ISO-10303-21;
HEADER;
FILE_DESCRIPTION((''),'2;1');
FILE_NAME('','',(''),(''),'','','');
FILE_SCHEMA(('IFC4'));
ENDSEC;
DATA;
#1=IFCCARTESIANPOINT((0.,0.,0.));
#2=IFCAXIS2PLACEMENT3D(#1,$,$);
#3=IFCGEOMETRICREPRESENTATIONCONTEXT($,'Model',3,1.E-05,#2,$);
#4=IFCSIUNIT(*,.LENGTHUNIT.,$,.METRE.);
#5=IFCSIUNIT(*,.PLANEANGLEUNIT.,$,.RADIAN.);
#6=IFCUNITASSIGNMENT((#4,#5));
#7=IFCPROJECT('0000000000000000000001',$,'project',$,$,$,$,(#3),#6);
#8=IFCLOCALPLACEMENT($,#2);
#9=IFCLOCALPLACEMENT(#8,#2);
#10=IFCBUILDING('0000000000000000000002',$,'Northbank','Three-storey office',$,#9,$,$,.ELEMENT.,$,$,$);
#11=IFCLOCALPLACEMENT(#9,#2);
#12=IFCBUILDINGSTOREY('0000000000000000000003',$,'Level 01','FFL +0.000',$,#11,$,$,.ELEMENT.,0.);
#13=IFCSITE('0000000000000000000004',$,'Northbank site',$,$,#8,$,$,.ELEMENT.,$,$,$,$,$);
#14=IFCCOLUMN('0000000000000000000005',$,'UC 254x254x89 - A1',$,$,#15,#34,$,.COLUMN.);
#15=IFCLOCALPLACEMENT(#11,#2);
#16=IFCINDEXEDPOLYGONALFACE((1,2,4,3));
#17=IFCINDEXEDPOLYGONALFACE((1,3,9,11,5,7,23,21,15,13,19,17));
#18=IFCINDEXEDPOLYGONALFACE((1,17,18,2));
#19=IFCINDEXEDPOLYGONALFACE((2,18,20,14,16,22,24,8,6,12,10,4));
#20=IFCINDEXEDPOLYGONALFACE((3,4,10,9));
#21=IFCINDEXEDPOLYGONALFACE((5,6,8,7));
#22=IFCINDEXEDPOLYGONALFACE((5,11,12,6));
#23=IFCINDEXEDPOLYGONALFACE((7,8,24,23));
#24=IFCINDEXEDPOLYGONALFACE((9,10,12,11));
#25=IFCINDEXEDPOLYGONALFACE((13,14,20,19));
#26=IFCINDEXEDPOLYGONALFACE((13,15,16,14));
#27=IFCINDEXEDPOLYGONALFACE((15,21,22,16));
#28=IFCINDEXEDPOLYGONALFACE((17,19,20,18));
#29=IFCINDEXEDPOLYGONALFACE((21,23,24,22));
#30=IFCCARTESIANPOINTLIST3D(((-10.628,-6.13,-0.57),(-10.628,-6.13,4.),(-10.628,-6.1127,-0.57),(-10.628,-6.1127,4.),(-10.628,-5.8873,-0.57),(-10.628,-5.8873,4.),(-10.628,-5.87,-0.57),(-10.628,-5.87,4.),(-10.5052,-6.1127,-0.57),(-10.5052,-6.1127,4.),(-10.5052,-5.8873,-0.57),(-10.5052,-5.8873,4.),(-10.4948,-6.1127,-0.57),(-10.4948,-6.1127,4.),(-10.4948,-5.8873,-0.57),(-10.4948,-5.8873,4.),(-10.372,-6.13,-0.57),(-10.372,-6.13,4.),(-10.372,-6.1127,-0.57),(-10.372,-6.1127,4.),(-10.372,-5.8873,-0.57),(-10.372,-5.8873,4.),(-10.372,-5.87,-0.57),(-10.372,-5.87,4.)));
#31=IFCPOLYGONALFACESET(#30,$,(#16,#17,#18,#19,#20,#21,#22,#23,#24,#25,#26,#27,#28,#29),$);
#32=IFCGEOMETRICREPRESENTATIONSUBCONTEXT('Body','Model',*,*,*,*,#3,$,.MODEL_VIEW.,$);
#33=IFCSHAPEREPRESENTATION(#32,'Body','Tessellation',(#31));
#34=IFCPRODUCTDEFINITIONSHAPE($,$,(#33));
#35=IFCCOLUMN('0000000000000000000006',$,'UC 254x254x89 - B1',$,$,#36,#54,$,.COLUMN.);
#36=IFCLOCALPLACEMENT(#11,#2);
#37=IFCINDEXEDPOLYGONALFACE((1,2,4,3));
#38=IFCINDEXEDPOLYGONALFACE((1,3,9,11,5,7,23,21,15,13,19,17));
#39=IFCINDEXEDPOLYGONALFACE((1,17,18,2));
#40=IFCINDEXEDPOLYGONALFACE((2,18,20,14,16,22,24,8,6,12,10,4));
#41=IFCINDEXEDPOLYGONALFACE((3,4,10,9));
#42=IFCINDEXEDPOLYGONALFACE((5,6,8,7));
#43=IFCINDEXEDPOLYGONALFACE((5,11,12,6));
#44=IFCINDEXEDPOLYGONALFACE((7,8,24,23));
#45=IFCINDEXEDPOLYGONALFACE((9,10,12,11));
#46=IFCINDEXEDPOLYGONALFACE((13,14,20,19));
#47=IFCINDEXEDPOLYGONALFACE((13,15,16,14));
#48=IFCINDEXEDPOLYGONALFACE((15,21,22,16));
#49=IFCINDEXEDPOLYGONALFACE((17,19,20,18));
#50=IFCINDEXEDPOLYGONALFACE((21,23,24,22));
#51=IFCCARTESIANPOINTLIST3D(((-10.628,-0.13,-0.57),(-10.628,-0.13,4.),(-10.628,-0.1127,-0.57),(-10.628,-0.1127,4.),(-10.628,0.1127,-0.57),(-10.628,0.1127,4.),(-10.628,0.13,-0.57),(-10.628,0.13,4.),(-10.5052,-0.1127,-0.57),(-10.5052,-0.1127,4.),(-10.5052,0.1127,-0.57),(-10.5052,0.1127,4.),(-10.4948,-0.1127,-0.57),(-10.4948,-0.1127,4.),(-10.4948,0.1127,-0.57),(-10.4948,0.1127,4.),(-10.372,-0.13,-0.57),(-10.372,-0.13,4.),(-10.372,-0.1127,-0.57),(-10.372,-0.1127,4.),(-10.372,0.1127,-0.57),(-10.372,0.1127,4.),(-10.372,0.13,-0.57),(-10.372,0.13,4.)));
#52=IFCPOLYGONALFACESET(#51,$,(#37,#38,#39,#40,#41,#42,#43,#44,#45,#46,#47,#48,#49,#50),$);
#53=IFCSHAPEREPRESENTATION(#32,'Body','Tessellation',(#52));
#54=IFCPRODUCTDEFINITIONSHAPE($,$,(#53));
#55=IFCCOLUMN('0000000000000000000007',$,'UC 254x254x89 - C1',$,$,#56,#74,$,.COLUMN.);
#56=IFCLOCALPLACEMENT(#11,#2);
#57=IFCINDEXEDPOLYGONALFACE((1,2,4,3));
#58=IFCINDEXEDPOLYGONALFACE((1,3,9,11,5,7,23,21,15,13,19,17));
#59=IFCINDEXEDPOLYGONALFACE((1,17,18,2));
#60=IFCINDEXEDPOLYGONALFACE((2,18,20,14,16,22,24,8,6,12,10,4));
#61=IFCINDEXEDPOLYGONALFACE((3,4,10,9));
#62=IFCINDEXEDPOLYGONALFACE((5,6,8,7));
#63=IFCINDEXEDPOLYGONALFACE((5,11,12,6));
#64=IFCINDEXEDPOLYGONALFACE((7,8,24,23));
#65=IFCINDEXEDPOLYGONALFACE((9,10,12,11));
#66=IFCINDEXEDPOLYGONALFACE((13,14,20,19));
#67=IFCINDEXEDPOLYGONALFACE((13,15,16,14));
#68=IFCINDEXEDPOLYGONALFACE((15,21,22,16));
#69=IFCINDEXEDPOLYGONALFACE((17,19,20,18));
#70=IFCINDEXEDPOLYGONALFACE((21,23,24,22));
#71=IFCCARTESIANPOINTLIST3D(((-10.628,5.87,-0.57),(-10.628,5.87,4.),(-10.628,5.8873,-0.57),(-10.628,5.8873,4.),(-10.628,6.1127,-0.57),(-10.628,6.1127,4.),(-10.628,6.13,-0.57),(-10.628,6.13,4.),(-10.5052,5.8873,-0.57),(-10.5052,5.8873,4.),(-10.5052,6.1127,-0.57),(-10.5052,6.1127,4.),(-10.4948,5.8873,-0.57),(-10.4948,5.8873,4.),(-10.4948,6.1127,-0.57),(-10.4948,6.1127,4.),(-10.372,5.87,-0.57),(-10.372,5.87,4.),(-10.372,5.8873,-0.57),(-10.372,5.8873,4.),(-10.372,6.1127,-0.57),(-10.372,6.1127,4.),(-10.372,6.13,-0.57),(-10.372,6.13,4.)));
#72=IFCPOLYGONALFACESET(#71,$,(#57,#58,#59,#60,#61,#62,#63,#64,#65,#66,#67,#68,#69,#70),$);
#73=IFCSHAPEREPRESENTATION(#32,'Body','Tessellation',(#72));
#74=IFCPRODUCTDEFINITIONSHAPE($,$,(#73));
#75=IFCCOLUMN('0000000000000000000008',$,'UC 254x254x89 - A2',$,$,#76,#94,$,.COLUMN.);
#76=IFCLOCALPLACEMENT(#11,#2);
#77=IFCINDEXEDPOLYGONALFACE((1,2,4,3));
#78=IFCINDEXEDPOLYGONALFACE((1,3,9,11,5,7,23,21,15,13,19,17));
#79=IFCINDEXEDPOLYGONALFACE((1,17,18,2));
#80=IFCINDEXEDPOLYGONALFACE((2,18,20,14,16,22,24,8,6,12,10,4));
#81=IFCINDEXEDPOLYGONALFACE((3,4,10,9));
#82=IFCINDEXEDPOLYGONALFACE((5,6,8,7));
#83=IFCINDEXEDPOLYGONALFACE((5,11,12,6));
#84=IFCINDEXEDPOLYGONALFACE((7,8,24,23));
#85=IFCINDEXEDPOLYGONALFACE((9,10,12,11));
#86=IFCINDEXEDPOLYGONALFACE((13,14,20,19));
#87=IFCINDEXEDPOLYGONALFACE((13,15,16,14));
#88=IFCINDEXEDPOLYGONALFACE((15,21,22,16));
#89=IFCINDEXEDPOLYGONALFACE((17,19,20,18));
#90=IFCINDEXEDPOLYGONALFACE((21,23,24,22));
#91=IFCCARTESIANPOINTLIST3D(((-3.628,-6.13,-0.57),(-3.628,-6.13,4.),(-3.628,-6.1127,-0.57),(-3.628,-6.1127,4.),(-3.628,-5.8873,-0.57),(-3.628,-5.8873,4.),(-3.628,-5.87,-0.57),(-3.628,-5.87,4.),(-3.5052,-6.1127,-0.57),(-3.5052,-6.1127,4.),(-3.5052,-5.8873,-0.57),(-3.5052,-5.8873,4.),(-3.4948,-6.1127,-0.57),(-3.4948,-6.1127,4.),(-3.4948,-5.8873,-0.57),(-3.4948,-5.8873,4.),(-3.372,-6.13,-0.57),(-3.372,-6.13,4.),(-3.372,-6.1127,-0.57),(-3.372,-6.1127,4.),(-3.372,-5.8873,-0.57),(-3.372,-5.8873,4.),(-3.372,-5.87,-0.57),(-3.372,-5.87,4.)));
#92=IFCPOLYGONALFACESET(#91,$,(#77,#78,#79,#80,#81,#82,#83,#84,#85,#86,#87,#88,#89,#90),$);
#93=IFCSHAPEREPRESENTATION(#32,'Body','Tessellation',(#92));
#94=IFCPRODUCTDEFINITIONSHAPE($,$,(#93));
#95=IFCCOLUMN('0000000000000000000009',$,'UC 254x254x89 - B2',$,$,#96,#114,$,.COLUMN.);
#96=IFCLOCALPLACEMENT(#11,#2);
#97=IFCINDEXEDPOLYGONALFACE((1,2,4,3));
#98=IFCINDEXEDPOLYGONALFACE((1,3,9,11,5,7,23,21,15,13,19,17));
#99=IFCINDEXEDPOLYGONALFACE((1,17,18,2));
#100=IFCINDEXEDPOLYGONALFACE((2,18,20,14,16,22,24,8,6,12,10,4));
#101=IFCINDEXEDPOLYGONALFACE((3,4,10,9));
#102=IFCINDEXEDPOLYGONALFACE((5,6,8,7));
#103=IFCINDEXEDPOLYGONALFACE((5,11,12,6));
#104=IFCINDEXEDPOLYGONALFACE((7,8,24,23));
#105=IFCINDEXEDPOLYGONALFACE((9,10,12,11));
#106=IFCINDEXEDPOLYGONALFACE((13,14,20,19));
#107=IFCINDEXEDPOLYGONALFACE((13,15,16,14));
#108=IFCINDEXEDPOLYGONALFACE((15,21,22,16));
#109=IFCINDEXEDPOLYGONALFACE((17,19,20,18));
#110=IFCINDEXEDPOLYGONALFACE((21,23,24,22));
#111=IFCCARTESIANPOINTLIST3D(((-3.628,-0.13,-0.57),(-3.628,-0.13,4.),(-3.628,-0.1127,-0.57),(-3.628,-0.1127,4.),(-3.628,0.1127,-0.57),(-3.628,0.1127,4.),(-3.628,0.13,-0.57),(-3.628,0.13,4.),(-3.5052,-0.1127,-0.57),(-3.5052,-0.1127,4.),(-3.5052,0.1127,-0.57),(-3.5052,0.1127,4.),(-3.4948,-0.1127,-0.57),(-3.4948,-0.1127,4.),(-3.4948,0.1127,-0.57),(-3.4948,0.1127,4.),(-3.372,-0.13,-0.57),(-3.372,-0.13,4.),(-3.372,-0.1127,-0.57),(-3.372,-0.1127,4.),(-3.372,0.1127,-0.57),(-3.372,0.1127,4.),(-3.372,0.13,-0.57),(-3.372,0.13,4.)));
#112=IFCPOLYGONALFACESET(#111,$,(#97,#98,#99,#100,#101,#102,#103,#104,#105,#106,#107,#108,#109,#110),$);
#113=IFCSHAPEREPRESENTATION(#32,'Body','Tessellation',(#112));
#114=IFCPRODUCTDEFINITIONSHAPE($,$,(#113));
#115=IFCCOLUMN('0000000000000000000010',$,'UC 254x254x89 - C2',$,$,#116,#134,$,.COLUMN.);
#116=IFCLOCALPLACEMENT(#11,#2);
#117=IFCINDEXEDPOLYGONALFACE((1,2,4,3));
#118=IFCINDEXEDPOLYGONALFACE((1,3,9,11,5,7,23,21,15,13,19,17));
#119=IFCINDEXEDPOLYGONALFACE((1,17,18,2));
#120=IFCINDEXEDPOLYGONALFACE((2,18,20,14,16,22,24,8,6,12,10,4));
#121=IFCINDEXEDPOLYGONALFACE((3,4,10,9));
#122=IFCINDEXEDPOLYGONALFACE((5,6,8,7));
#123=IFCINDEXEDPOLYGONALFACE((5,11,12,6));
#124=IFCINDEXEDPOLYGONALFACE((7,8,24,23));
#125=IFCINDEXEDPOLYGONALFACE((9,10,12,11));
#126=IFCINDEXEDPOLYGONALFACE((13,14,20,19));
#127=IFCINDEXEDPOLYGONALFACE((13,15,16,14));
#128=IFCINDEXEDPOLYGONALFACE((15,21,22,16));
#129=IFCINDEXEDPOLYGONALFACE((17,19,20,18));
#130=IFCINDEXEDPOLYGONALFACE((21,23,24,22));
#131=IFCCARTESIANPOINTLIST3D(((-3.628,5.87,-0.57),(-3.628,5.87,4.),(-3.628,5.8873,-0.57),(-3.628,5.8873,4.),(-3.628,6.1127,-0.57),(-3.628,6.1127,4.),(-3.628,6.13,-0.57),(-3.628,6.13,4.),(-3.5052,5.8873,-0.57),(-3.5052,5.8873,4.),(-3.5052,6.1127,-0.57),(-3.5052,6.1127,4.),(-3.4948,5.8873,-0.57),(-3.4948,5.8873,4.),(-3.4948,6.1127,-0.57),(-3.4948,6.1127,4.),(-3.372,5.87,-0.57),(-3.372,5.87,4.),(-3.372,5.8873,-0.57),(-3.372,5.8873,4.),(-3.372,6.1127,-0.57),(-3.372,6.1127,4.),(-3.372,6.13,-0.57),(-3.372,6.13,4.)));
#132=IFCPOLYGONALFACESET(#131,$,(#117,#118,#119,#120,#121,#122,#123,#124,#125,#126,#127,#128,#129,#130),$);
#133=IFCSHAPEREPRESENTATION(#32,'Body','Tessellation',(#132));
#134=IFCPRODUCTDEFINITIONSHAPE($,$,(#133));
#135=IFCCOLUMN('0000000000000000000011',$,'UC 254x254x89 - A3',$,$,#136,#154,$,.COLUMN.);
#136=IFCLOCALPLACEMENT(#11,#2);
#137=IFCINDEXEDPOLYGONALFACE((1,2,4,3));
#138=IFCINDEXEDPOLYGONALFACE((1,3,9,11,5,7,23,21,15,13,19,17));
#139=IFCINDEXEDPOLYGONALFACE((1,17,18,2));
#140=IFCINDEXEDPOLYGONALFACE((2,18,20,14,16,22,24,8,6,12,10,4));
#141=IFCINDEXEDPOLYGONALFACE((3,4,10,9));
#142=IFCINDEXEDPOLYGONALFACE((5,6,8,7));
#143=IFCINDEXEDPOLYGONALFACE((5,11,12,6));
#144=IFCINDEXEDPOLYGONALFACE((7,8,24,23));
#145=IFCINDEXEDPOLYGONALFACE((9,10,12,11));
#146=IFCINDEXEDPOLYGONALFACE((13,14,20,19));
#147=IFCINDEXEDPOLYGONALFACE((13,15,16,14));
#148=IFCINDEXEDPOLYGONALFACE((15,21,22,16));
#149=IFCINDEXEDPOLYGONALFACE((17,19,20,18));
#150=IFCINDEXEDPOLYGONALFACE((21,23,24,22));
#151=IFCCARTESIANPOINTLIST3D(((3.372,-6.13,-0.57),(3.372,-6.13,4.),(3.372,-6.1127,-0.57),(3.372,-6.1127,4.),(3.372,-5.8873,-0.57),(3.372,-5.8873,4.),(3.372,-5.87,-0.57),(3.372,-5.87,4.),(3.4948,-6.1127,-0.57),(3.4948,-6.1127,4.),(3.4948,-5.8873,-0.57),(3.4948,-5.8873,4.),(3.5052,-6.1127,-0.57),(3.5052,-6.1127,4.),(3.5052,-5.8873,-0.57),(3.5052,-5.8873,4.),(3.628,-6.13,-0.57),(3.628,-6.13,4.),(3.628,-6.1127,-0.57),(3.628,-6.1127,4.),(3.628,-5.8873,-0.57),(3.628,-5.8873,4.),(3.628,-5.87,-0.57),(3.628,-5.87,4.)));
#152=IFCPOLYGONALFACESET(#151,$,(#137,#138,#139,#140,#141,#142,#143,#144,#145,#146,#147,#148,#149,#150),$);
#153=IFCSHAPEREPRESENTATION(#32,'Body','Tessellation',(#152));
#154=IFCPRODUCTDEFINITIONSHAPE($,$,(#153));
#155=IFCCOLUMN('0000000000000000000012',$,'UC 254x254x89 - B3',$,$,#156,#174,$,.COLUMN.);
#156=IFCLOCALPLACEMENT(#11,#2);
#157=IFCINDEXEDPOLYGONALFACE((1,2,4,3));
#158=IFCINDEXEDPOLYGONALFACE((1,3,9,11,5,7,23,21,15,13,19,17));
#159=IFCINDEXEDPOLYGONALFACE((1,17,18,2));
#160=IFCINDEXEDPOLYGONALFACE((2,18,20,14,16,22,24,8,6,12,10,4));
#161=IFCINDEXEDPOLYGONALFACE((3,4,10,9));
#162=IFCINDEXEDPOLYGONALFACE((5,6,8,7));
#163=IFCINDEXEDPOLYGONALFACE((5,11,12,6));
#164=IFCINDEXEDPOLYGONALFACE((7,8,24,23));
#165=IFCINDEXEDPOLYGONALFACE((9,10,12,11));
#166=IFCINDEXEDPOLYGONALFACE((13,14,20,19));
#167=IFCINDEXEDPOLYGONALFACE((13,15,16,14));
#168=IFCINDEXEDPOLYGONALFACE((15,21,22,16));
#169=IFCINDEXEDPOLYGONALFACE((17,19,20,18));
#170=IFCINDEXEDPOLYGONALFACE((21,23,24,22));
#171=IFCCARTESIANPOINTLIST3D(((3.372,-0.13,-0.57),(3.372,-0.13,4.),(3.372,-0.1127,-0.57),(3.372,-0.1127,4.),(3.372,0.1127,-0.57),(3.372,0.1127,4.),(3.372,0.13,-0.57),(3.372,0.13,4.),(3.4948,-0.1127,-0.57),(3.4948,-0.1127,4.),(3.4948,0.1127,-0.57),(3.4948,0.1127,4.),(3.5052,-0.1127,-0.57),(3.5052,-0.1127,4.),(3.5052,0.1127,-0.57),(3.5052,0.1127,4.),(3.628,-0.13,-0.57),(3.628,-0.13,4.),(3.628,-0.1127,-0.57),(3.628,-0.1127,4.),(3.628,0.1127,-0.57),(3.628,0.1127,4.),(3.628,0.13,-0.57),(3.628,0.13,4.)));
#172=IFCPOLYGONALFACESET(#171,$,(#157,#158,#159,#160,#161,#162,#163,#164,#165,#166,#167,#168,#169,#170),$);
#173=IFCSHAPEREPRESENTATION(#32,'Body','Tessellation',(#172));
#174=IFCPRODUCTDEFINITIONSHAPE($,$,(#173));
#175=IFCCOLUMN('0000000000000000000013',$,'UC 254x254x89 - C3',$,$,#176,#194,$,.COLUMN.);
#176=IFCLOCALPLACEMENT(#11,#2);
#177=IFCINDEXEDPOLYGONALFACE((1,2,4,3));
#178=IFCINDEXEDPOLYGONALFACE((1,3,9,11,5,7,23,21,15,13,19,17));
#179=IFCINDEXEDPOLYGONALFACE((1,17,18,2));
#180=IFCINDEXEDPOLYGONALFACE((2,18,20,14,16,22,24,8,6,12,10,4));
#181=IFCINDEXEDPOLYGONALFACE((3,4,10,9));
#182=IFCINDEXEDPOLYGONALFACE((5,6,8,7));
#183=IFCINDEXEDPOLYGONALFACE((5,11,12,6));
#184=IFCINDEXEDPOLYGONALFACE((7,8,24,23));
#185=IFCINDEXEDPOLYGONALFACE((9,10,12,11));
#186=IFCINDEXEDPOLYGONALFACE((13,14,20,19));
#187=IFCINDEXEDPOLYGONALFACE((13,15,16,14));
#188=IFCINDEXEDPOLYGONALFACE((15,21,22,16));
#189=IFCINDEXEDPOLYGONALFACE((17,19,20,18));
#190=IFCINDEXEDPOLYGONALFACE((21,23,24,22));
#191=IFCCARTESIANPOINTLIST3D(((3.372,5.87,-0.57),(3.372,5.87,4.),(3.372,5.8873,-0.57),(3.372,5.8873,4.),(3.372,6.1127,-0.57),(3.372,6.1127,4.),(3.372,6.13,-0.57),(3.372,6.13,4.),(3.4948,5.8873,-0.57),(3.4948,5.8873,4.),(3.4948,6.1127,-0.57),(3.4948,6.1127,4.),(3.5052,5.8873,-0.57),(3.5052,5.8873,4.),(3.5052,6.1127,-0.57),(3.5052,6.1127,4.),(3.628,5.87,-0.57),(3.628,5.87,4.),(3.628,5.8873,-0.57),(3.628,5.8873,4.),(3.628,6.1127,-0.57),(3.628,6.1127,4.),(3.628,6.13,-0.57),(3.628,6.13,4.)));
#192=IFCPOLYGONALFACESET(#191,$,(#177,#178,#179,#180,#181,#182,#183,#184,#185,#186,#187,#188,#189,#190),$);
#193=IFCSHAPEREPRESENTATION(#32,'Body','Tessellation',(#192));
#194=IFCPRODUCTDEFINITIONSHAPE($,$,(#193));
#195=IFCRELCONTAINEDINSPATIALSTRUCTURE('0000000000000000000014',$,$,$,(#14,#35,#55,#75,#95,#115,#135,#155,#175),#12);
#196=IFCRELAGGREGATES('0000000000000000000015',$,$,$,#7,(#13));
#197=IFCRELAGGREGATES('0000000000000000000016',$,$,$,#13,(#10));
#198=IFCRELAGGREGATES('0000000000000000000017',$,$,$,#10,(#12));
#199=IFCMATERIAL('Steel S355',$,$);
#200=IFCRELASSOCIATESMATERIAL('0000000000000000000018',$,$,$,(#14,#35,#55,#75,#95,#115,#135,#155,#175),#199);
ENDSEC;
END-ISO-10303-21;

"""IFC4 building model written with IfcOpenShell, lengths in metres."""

from ifc_helpers import new_model, si_unit, frame, origin, place, context, subcontext, project, spatial, i_section, extrude, material, element, save


model = new_model("IFC4")

# Units and contexts
model_context = context("Model", 3, precision=1e-05, world=origin())
body_context = subcontext(model_context, "Body", "Model", "MODEL_VIEW")
ifc_project = project(units=[si_unit("LENGTHUNIT", "METRE"), si_unit("PLANEANGLEUNIT", "RADIAN")], contexts=[model_context])

# Site, building, storey
site_placement = place(None, origin())
site = spatial("IfcSite", under=ifc_project, at=site_placement, Name="Northbank site", CompositionType="ELEMENT")
building_placement = place(site_placement, origin())
building = spatial("IfcBuilding", under=site, at=building_placement, Name="Northbank", Description="Three-storey office", CompositionType="ELEMENT")
storey_placement = place(building_placement, origin())
storey = spatial("IfcBuildingStorey", under=building, at=storey_placement, Name="Level 01", Description="FFL +0.000", CompositionType="ELEMENT", Elevation=0.0)

# Columns
ifc_material_1 = material(Name="Steel S355")
column_1_placement = place(storey_placement, origin())
element("IfcColumn", 1, at=column_1_placement, inside=storey, material=ifc_material_1, Name="UC 254x254x89 - A1", PredefinedType="COLUMN", context=body_context, shape_type="SweptSolid", body=[
    extrude(i_section(OverallWidth=0.256, OverallDepth=0.26, WebThickness=0.0103, FlangeThickness=0.0173), frame((-10.5, -6.0, -0.57), z_axis=(0.0, 0.0, 1.0), x_axis=(1.0, 0.0, 0.0)), (0.0, 0.0, 1.0), 4.57),
])
column_2_placement = place(storey_placement, origin())
element("IfcColumn", 2, at=column_2_placement, inside=storey, material=ifc_material_1, Name="UC 254x254x89 - B1", PredefinedType="COLUMN", context=body_context, shape_type="SweptSolid", body=[
    extrude(i_section(OverallWidth=0.256, OverallDepth=0.26, WebThickness=0.0103, FlangeThickness=0.0173), frame((-10.5, 0.0, -0.57), z_axis=(0.0, 0.0, 1.0), x_axis=(1.0, 0.0, 0.0)), (0.0, 0.0, 1.0), 4.57),
])
column_3_placement = place(storey_placement, origin())
element("IfcColumn", 3, at=column_3_placement, inside=storey, material=ifc_material_1, Name="UC 254x254x89 - C1", PredefinedType="COLUMN", context=body_context, shape_type="SweptSolid", body=[
    extrude(i_section(OverallWidth=0.256, OverallDepth=0.26, WebThickness=0.0103, FlangeThickness=0.0173), frame((-10.5, 6.0, -0.57), z_axis=(0.0, 0.0, 1.0), x_axis=(1.0, 0.0, 0.0)), (0.0, 0.0, 1.0), 4.57),
])
column_4_placement = place(storey_placement, origin())
element("IfcColumn", 4, at=column_4_placement, inside=storey, material=ifc_material_1, Name="UC 254x254x89 - A2", PredefinedType="COLUMN", context=body_context, shape_type="SweptSolid", body=[
    extrude(i_section(OverallWidth=0.256, OverallDepth=0.26, WebThickness=0.0103, FlangeThickness=0.0173), frame((-3.5, -6.0, -0.57), z_axis=(0.0, 0.0, 1.0), x_axis=(1.0, 0.0, 0.0)), (0.0, 0.0, 1.0), 4.57),
])
column_5_placement = place(storey_placement, origin())
element("IfcColumn", 5, at=column_5_placement, inside=storey, material=ifc_material_1, Name="UC 254x254x89 - B2", PredefinedType="COLUMN", context=body_context, shape_type="SweptSolid", body=[
    extrude(i_section(OverallWidth=0.256, OverallDepth=0.26, WebThickness=0.0103, FlangeThickness=0.0173), frame((-3.5, 0.0, -0.57), z_axis=(0.0, 0.0, 1.0), x_axis=(1.0, 0.0, 0.0)), (0.0, 0.0, 1.0), 4.57),
])
column_6_placement = place(storey_placement, origin())
element("IfcColumn", 6, at=column_6_placement, inside=storey, material=ifc_material_1, Name="UC 254x254x89 - C2", PredefinedType="COLUMN", context=body_context, shape_type="SweptSolid", body=[
    extrude(i_section(OverallWidth=0.256, OverallDepth=0.26, WebThickness=0.0103, FlangeThickness=0.0173), frame((-3.5, 6.0, -0.57), z_axis=(0.0, 0.0, 1.0), x_axis=(1.0, 0.0, 0.0)), (0.0, 0.0, 1.0), 4.57),
])
column_7_placement = place(storey_placement, origin())
element("IfcColumn", 7, at=column_7_placement, inside=storey, material=ifc_material_1, Name="UC 254x254x89 - A3", PredefinedType="COLUMN", context=body_context, shape_type="SweptSolid", body=[
    extrude(i_section(OverallWidth=0.256, OverallDepth=0.26, WebThickness=0.0103, FlangeThickness=0.0173), frame((3.5, -6.0, -0.57), z_axis=(0.0, 0.0, 1.0), x_axis=(1.0, 0.0, 0.0)), (0.0, 0.0, 1.0), 4.57),
])
column_8_placement = place(storey_placement, origin())
element("IfcColumn", 8, at=column_8_placement, inside=storey, material=ifc_material_1, Name="UC 254x254x89 - B3", PredefinedType="COLUMN", context=body_context, shape_type="SweptSolid", body=[
    extrude(i_section(OverallWidth=0.256, OverallDepth=0.26, WebThickness=0.0103, FlangeThickness=0.0173), frame((3.5, 0.0, -0.57), z_axis=(0.0, 0.0, 1.0), x_axis=(1.0, 0.0, 0.0)), (0.0, 0.0, 1.0), 4.57),
])
column_9_placement = place(storey_placement, origin())
element("IfcColumn", 9, at=column_9_placement, inside=storey, material=ifc_material_1, Name="UC 254x254x89 - C3", PredefinedType="COLUMN", context=body_context, shape_type="SweptSolid", body=[
    extrude(i_section(OverallWidth=0.256, OverallDepth=0.26, WebThickness=0.0103, FlangeThickness=0.0173), frame((3.5, 6.0, -0.57), z_axis=(0.0, 0.0, 1.0), x_axis=(1.0, 0.0, 0.0)), (0.0, 0.0, 1.0), 4.57),
])

save(model, "model.ifc")
